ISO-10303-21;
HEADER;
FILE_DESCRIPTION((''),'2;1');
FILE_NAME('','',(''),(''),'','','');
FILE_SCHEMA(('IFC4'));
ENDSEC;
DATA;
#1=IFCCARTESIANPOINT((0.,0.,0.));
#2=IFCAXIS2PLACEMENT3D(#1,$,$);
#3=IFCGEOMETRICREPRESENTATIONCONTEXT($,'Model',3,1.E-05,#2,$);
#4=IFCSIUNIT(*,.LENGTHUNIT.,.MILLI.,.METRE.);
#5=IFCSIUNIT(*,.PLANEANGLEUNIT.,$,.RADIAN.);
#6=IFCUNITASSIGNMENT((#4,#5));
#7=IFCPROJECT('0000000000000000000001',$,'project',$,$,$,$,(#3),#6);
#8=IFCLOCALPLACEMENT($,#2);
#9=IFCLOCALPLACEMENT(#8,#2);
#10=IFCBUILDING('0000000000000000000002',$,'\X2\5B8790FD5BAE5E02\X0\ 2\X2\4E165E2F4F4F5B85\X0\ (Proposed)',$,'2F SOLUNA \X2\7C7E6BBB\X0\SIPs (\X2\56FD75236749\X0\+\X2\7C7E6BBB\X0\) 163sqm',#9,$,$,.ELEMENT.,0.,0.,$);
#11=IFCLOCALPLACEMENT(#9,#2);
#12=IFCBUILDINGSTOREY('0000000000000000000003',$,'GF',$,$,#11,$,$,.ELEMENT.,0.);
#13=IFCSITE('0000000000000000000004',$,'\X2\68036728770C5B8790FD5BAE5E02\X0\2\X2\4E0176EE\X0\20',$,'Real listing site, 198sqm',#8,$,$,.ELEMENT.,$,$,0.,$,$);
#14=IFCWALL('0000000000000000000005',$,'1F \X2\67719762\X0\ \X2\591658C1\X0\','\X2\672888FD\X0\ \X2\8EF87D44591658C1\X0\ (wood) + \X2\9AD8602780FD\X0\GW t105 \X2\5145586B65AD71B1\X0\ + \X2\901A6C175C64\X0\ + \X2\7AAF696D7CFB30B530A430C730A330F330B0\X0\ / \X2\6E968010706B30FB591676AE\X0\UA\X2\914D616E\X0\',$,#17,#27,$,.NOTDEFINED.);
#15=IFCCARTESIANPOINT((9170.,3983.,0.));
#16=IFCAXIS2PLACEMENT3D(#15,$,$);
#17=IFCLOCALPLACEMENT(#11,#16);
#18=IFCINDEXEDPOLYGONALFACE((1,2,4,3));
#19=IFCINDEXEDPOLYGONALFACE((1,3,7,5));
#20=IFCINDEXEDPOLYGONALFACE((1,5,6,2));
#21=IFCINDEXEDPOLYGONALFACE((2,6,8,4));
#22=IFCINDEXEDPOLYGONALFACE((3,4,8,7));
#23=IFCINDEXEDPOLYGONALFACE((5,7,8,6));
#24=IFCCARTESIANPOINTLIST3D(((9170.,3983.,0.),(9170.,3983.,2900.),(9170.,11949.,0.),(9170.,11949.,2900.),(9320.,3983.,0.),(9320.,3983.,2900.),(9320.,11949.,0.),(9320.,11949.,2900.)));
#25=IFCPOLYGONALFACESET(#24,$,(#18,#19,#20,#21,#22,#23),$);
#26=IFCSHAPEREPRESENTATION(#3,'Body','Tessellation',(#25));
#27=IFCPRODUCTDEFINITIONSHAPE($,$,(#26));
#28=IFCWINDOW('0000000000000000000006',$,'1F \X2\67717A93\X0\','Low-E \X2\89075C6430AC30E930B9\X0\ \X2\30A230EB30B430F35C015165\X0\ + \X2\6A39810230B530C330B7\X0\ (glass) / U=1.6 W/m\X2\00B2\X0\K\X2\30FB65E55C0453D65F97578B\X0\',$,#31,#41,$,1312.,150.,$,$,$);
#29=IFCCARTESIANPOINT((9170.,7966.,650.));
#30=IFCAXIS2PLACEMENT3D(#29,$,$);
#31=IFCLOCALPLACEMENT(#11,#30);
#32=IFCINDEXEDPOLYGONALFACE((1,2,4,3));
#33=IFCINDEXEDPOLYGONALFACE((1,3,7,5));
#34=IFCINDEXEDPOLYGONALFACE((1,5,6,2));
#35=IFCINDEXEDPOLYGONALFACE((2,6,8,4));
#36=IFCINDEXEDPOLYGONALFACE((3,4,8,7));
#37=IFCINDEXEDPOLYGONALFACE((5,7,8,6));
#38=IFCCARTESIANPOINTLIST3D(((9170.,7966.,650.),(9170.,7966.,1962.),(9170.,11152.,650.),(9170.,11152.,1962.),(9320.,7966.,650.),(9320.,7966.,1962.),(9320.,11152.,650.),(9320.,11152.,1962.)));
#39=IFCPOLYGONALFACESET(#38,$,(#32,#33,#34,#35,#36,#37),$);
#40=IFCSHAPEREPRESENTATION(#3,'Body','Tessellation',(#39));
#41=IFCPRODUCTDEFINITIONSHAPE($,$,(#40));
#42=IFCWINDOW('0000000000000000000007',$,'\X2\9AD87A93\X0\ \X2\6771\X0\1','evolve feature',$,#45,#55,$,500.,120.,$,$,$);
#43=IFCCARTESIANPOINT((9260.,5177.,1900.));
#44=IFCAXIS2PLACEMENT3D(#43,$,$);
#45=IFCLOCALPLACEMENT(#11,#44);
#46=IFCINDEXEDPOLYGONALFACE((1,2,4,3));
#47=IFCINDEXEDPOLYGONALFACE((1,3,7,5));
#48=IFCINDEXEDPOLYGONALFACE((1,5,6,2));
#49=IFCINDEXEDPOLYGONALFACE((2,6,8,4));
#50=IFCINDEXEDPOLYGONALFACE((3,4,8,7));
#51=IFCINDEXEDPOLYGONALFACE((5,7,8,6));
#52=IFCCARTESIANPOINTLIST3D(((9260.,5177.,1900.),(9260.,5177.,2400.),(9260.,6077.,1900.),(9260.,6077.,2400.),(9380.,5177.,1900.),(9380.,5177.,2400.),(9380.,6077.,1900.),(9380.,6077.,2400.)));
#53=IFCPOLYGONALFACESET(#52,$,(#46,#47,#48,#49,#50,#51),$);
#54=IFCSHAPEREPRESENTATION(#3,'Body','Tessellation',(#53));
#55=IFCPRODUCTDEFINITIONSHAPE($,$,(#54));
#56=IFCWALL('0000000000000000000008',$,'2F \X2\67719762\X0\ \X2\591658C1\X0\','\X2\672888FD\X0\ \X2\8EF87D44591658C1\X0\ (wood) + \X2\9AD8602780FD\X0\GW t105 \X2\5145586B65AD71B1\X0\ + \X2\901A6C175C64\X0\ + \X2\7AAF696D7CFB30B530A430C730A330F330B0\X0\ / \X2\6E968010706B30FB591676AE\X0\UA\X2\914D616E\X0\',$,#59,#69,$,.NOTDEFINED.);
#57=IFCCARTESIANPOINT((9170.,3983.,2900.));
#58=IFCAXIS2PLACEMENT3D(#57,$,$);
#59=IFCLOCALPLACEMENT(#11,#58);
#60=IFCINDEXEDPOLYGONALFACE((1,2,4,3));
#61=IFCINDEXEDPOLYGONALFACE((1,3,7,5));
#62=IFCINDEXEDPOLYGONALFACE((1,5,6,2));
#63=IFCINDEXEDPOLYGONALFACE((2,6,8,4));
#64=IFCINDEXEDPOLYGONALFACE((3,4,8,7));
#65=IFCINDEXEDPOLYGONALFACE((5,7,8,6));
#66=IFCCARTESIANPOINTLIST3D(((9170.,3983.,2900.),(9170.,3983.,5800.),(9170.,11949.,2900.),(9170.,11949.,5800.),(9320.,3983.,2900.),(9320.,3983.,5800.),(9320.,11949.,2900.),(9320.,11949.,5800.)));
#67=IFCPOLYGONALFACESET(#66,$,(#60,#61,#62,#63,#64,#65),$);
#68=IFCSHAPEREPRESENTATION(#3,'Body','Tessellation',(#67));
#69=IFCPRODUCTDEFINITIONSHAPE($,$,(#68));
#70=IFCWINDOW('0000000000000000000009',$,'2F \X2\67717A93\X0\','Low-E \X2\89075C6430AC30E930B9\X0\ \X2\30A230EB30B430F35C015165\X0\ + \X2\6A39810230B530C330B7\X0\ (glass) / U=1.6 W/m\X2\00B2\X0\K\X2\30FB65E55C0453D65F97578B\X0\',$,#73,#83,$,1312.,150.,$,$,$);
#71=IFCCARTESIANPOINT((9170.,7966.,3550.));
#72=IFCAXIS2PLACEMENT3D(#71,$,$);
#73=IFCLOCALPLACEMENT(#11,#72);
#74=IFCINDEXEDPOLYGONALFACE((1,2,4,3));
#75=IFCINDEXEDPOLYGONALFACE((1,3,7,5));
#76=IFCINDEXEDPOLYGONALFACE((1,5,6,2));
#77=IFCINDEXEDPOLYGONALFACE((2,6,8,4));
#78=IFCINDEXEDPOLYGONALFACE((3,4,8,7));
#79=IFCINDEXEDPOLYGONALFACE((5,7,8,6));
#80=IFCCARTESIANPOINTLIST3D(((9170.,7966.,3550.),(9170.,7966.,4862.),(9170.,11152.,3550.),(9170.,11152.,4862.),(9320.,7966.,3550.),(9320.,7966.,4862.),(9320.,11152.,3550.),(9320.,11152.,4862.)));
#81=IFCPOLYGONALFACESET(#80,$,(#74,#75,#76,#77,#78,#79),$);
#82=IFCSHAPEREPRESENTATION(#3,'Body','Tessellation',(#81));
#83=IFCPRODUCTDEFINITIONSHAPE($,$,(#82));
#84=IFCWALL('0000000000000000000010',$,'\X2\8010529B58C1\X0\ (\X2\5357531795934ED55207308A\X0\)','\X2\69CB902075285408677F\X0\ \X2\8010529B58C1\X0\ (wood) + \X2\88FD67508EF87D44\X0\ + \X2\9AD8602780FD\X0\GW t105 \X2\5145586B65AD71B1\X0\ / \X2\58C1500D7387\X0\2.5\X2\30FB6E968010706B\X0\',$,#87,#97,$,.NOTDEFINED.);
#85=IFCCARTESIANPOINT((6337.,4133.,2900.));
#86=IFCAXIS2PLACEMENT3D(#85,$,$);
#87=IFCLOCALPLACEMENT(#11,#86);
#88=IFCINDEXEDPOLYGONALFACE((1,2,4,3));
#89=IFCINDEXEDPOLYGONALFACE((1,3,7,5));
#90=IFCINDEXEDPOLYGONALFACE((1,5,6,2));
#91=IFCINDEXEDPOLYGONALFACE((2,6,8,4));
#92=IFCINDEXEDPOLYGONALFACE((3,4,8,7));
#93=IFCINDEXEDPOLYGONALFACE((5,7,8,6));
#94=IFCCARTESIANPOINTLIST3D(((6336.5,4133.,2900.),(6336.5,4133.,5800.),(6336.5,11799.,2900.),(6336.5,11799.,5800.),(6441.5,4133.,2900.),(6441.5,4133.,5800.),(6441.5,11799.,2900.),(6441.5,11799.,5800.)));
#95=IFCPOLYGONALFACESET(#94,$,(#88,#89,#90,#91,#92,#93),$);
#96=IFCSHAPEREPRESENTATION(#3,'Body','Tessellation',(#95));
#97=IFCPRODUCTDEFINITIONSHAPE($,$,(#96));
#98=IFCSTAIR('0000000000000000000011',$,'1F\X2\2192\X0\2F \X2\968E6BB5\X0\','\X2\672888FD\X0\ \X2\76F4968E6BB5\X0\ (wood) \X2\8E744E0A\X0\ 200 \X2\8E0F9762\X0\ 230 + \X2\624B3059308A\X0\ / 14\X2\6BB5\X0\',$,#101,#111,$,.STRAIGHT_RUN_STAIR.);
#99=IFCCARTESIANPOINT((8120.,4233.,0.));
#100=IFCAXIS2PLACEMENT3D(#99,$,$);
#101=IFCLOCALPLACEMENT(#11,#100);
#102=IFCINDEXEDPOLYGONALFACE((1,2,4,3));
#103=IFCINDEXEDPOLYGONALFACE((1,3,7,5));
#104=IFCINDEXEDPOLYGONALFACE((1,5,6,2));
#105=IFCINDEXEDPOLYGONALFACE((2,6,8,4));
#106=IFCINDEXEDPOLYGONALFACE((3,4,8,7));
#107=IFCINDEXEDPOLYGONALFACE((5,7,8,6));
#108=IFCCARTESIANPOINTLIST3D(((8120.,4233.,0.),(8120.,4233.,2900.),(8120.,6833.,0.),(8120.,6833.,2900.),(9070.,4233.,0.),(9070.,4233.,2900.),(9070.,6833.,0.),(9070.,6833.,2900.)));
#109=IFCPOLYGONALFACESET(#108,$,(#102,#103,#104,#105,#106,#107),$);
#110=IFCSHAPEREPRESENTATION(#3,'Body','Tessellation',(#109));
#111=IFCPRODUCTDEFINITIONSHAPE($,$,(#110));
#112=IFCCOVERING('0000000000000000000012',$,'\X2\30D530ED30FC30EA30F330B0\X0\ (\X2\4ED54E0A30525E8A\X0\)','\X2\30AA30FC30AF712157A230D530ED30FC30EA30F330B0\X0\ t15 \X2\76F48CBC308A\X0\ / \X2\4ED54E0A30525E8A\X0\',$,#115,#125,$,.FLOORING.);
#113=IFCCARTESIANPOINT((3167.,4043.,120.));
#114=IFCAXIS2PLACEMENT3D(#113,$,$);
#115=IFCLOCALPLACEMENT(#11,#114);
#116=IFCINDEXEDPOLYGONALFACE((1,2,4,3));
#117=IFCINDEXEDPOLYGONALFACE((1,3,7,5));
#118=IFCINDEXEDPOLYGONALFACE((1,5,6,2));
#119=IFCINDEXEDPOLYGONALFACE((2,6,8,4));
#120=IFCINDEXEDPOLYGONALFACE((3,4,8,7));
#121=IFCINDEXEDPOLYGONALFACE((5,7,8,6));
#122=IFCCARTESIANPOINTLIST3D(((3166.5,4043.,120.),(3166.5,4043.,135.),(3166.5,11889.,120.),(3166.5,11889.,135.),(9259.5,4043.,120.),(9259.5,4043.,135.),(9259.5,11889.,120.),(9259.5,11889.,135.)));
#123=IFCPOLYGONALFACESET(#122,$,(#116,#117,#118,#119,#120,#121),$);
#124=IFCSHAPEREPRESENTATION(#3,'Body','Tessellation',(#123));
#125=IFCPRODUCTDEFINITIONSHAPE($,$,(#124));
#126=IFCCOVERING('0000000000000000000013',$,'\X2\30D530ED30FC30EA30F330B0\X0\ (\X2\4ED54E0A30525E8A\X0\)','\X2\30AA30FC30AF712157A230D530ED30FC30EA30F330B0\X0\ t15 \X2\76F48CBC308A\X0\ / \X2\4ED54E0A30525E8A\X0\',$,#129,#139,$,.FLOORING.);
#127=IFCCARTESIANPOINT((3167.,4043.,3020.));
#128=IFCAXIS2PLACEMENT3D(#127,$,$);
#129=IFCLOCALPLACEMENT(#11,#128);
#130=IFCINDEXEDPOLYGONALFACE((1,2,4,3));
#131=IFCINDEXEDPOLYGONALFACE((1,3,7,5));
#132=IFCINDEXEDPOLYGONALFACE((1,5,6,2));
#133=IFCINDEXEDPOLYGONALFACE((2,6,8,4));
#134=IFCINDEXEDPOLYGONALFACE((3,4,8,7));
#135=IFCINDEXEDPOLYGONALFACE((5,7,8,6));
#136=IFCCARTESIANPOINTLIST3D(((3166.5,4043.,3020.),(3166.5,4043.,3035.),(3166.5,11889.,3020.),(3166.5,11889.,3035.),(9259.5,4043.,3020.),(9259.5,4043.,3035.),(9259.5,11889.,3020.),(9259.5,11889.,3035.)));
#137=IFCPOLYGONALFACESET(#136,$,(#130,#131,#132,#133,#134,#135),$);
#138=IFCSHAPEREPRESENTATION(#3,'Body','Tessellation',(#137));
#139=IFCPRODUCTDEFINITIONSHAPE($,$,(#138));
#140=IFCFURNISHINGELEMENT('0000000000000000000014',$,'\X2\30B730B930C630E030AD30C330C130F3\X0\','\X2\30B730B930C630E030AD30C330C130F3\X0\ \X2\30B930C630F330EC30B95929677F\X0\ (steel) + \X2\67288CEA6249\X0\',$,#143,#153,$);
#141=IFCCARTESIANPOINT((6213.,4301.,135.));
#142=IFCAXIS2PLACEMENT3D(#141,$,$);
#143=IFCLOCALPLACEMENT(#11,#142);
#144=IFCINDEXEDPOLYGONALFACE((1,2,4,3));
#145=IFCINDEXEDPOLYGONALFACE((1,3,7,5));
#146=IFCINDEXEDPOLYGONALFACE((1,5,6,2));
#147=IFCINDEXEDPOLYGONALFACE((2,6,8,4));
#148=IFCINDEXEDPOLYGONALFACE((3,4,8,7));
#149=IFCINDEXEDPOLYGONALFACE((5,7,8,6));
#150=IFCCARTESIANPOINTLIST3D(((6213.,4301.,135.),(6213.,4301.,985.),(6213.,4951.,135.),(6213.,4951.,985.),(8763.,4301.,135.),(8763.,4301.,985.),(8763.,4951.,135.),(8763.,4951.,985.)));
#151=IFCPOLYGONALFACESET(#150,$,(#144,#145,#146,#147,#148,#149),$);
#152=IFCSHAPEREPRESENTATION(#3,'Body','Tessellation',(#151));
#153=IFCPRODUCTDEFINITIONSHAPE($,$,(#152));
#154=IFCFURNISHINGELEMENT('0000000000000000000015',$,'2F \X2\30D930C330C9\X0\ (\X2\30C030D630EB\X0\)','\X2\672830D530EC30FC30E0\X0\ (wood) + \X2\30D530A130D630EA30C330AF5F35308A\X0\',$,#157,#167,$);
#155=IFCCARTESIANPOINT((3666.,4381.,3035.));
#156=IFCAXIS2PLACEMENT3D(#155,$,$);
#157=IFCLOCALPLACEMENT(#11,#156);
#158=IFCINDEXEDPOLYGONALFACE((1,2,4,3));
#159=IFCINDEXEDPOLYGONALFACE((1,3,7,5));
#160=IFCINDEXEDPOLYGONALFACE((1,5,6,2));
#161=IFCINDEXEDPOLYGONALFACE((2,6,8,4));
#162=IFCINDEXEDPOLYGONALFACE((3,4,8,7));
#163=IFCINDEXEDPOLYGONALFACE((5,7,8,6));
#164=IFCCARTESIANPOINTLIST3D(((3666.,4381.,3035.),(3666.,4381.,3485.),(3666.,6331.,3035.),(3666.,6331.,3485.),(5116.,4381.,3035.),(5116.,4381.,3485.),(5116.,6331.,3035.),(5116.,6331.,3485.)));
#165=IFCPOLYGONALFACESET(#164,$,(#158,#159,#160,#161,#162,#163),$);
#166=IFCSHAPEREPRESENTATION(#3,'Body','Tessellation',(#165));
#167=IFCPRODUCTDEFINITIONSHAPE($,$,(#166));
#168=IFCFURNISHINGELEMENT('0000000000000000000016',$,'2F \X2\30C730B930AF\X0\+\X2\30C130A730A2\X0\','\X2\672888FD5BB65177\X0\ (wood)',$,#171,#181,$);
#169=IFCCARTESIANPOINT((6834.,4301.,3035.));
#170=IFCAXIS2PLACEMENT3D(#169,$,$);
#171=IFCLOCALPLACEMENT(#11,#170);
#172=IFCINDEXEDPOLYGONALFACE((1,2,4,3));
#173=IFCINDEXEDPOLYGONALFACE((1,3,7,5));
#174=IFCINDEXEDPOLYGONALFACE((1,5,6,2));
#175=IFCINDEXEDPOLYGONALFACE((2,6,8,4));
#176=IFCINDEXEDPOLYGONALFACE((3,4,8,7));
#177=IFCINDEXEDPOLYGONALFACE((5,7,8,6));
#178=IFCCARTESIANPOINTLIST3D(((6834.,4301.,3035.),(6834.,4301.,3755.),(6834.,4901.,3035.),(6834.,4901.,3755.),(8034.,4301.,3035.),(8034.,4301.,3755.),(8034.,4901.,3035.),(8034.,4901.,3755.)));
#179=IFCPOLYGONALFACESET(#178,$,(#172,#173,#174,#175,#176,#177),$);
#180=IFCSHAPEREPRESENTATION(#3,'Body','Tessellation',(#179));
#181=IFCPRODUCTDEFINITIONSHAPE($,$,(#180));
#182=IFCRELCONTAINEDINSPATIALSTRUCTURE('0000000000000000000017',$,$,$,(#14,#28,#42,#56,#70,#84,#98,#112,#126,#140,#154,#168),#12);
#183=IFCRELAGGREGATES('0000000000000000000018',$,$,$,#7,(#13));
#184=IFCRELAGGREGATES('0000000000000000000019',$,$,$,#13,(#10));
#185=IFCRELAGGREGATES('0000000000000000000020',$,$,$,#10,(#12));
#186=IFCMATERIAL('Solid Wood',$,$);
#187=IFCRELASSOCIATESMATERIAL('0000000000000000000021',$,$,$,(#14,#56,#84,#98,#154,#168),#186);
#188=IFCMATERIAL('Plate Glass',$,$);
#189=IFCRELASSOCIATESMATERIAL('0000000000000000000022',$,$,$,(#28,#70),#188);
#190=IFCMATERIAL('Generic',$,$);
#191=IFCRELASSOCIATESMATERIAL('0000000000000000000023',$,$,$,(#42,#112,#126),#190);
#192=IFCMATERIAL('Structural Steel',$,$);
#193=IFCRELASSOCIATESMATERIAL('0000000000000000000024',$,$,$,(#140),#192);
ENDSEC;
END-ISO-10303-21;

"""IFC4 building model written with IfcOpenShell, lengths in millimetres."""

from ifc_helpers import new_model, si_unit, frame, frame_2d, origin, place, context, project, spatial, rectangle, extrude, material, element, fill, save


model = new_model("IFC4")

# Units and contexts
model_context = context("Model", 3, precision=1e-05, world=origin())
ifc_project = project(units=[si_unit("LENGTHUNIT", "METRE", prefix="MILLI"), si_unit("PLANEANGLEUNIT", "RADIAN")], contexts=[model_context])

# Site, building, storey
site_placement = place(None, origin())
site = spatial("IfcSite", under=ifc_project, at=site_placement, Name="栃木県宇都宮市2丁目20", ObjectType="Real listing site, 198sqm", CompositionType="ELEMENT", RefElevation=0.0)
building_placement = place(site_placement, origin())
building = spatial("IfcBuilding", under=site, at=building_placement, Name="宇都宮市 2世帯住宅 (Proposed)", ObjectType="2F SOLUNA 籾殻SIPs (国産杉+籾殻) 163sqm", CompositionType="ELEMENT", ElevationOfRefHeight=0.0, ElevationOfTerrain=0.0)
storey_placement = place(building_placement, origin())
storey = spatial("IfcBuildingStorey", under=building, at=storey_placement, Name="GF", CompositionType="ELEMENT", Elevation=0.0)

# Shared definitions
ifc_material_1 = material(Name="Solid Wood")

# Wall, openings, windows
wall_1_placement = place(storey_placement, frame((9170.0, 3983.0, 0.0)))
wall_1 = element("IfcWall", 1, at=wall_1_placement, inside=storey, material=ifc_material_1, Name="1F 東面 外壁", Description="木製 軸組外壁 (wood) + 高性能GW t105 充填断熱 + 通気層 + 窯業系サイディング / 準耐火・外皮UA配慮", PredefinedType="NOTDEFINED", context=model_context, shape_type="SweptSolid", body=[
    extrude(rectangle(XDim=150.0, YDim=7966.0, at=frame_2d((75.0, 3983.0))), frame((9170.0, 3983.0, 0.0)), (0.0, 0.0, 1.0), 2900.0),
])
opening_1_placement = place(storey_placement, frame((9170.0, 7966.0, 650.0)))
opening_1 = element("IfcOpeningElement", 2, at=opening_1_placement, cuts=wall_1, PredefinedType="NOTDEFINED", context=model_context, shape_type="SweptSolid", body=[
    extrude(rectangle(XDim=150.0, YDim=3186.0, at=frame_2d((75.0, 1593.0))), frame((9170.0, 7966.0, 650.0)), (0.0, 0.0, 1.0), 1312.0),
])
opening_2_placement = place(storey_placement, frame((9260.0, 5177.0, 1900.0)))
opening_2 = element("IfcOpeningElement", 3, at=opening_2_placement, cuts=wall_1, PredefinedType="NOTDEFINED", context=model_context, shape_type="SweptSolid", body=[
    extrude(rectangle(XDim=120.0, YDim=900.0, at=frame_2d((60.0, 450.0))), frame((9260.0, 5177.0, 1900.0)), (0.0, 0.0, 1.0), 500.0),
])
ifc_material_2 = material(Name="Plate Glass")
window_1_placement = place(storey_placement, frame((9170.0, 7966.0, 650.0)))
window_1 = element("IfcWindow", 4, at=window_1_placement, inside=storey, material=ifc_material_2, Name="1F 東窓", Description="Low-E 複層ガラス アルゴン封入 + 樹脂サッシ (glass) / U=1.6 W/m²K・日射取得型", OverallHeight=1312.0, OverallWidth=150.0, context=model_context, shape_type="SweptSolid", body=[
    extrude(rectangle(XDim=150.0, YDim=3186.0, at=frame_2d((75.0, 1593.0))), frame((9170.0, 7966.0, 650.0)), (0.0, 0.0, 1.0), 1312.0),
])
fill(opening_1, window_1)
ifc_material_3 = material(Name="Generic")
window_2_placement = place(storey_placement, frame((9260.0, 5177.0, 1900.0)))
window_2 = element("IfcWindow", 5, at=window_2_placement, inside=storey, material=ifc_material_3, Name="高窓 東1", Description="evolve feature", OverallHeight=500.0, OverallWidth=120.0, context=model_context, shape_type="SweptSolid", body=[
    extrude(rectangle(XDim=120.0, YDim=900.0, at=frame_2d((60.0, 450.0))), frame((9260.0, 5177.0, 1900.0)), (0.0, 0.0, 1.0), 500.0),
])
fill(opening_2, window_2)

# Wall, opening, window
wall_2_placement = place(storey_placement, frame((9170.0, 3983.0, 2900.0)))
wall_2 = element("IfcWall", 6, at=wall_2_placement, inside=storey, material=ifc_material_1, Name="2F 東面 外壁", Description="木製 軸組外壁 (wood) + 高性能GW t105 充填断熱 + 通気層 + 窯業系サイディング / 準耐火・外皮UA配慮", PredefinedType="NOTDEFINED", context=model_context, shape_type="SweptSolid", body=[
    extrude(rectangle(XDim=150.0, YDim=7966.0, at=frame_2d((75.0, 3983.0))), frame((9170.0, 3983.0, 2900.0)), (0.0, 0.0, 1.0), 2900.0),
])
opening_3_placement = place(storey_placement, frame((9170.0, 7966.0, 3550.0)))
opening_3 = element("IfcOpeningElement", 7, at=opening_3_placement, cuts=wall_2, PredefinedType="NOTDEFINED", context=model_context, shape_type="SweptSolid", body=[
    extrude(rectangle(XDim=150.0, YDim=3186.0, at=frame_2d((75.0, 1593.0))), frame((9170.0, 7966.0, 3550.0)), (0.0, 0.0, 1.0), 1312.0),
])
window_3_placement = place(storey_placement, frame((9170.0, 7966.0, 3550.0)))
window_3 = element("IfcWindow", 8, at=window_3_placement, inside=storey, material=ifc_material_2, Name="2F 東窓", Description="Low-E 複層ガラス アルゴン封入 + 樹脂サッシ (glass) / U=1.6 W/m²K・日射取得型", OverallHeight=1312.0, OverallWidth=150.0, context=model_context, shape_type="SweptSolid", body=[
    extrude(rectangle(XDim=150.0, YDim=3186.0, at=frame_2d((75.0, 1593.0))), frame((9170.0, 7966.0, 3550.0)), (0.0, 0.0, 1.0), 1312.0),
])
fill(opening_3, window_3)

# Wall
wall_3_placement = place(storey_placement, frame((6337.0, 4133.0, 2900.0)))
element("IfcWall", 9, at=wall_3_placement, inside=storey, material=ifc_material_1, Name="耐力壁 (南北間仕切り)", Description="構造用合板 耐力壁 (wood) + 製材軸組 + 高性能GW t105 充填断熱 / 壁倍率2.5・準耐火", PredefinedType="NOTDEFINED", context=model_context, shape_type="SweptSolid", body=[
    extrude(rectangle(XDim=105.0, YDim=7666.0, at=frame_2d((52.0, 3833.0))), frame((6337.0, 4133.0, 2900.0)), (0.0, 0.0, 1.0), 2900.0),
])

# Stair
stair_placement = place(storey_placement, frame((8120.0, 4233.0, 0.0)))
element("IfcStair", 10, at=stair_placement, inside=storey, material=ifc_material_1, Name="1F→2F 階段", Description="木製 直階段 (wood) 蹴上 200 踏面 230 + 手すり / 14段", PredefinedType="STRAIGHT_RUN_STAIR", context=model_context, shape_type="SweptSolid", body=[
    extrude(rectangle(XDim=950.0, YDim=2600.0, at=frame_2d((475.0, 1300.0))), frame((8120.0, 4233.0, 0.0)), (0.0, 0.0, 1.0), 2900.0),
])

# Coverings
covering_1_placement = place(storey_placement, frame((3167.0, 4043.0, 120.0)))
element("IfcCovering", 11, at=covering_1_placement, inside=storey, material=ifc_material_3, Name="フローリング (仕上げ床)", Description="オーク無垢フローリング t15 直貼り / 仕上げ床", PredefinedType="FLOORING", context=model_context, shape_type="SweptSolid", body=[
    extrude(rectangle(XDim=6093.0, YDim=7846.0, at=frame_2d((3046.0, 3923.0))), frame((3167.0, 4043.0, 120.0)), (0.0, 0.0, 1.0), 15.0),
])
covering_2_placement = place(storey_placement, frame((3167.0, 4043.0, 3020.0)))
element("IfcCovering", 12, at=covering_2_placement, inside=storey, material=ifc_material_3, Name="フローリング (仕上げ床)", Description="オーク無垢フローリング t15 直貼り / 仕上げ床", PredefinedType="FLOORING", context=model_context, shape_type="SweptSolid", body=[
    extrude(rectangle(XDim=6093.0, YDim=7846.0, at=frame_2d((3046.0, 3923.0))), frame((3167.0, 4043.0, 3020.0)), (0.0, 0.0, 1.0), 15.0),
])

# Furnishing elements
ifc_material_4 = material(Name="Structural Steel")
furnishing_1_placement = place(storey_placement, frame((6213.0, 4301.0, 135.0)))
element("IfcFurnishingElement", 13, at=furnishing_1_placement, inside=storey, material=ifc_material_4, Name="システムキッチン", Description="システムキッチン ステンレス天板 (steel) + 木質扉", context=model_context, shape_type="SweptSolid", body=[
    extrude(rectangle(XDim=2550.0, YDim=650.0, at=frame_2d((1275.0, 325.0))), frame((6213.0, 4301.0, 135.0)), (0.0, 0.0, 1.0), 850.0),
])
furnishing_2_placement = place(storey_placement, frame((3666.0, 4381.0, 3035.0)))
element("IfcFurnishingElement", 14, at=furnishing_2_placement, inside=storey, material=ifc_material_1, Name="2F ベッド (ダブル)", Description="木フレーム (wood) + ファブリック張り", context=model_context, shape_type="SweptSolid", body=[
    extrude(rectangle(XDim=1450.0, YDim=1950.0, at=frame_2d((725.0, 975.0))), frame((3666.0, 4381.0, 3035.0)), (0.0, 0.0, 1.0), 450.0),
])
furnishing_3_placement = place(storey_placement, frame((6834.0, 4301.0, 3035.0)))
element("IfcFurnishingElement", 15, at=furnishing_3_placement, inside=storey, material=ifc_material_1, Name="2F デスク+チェア", Description="木製家具 (wood)", context=model_context, shape_type="SweptSolid", body=[
    extrude(rectangle(XDim=1200.0, YDim=600.0, at=frame_2d((600.0, 300.0))), frame((6834.0, 4301.0, 3035.0)), (0.0, 0.0, 1.0), 720.0),
])

save(model, "model.ifc")
